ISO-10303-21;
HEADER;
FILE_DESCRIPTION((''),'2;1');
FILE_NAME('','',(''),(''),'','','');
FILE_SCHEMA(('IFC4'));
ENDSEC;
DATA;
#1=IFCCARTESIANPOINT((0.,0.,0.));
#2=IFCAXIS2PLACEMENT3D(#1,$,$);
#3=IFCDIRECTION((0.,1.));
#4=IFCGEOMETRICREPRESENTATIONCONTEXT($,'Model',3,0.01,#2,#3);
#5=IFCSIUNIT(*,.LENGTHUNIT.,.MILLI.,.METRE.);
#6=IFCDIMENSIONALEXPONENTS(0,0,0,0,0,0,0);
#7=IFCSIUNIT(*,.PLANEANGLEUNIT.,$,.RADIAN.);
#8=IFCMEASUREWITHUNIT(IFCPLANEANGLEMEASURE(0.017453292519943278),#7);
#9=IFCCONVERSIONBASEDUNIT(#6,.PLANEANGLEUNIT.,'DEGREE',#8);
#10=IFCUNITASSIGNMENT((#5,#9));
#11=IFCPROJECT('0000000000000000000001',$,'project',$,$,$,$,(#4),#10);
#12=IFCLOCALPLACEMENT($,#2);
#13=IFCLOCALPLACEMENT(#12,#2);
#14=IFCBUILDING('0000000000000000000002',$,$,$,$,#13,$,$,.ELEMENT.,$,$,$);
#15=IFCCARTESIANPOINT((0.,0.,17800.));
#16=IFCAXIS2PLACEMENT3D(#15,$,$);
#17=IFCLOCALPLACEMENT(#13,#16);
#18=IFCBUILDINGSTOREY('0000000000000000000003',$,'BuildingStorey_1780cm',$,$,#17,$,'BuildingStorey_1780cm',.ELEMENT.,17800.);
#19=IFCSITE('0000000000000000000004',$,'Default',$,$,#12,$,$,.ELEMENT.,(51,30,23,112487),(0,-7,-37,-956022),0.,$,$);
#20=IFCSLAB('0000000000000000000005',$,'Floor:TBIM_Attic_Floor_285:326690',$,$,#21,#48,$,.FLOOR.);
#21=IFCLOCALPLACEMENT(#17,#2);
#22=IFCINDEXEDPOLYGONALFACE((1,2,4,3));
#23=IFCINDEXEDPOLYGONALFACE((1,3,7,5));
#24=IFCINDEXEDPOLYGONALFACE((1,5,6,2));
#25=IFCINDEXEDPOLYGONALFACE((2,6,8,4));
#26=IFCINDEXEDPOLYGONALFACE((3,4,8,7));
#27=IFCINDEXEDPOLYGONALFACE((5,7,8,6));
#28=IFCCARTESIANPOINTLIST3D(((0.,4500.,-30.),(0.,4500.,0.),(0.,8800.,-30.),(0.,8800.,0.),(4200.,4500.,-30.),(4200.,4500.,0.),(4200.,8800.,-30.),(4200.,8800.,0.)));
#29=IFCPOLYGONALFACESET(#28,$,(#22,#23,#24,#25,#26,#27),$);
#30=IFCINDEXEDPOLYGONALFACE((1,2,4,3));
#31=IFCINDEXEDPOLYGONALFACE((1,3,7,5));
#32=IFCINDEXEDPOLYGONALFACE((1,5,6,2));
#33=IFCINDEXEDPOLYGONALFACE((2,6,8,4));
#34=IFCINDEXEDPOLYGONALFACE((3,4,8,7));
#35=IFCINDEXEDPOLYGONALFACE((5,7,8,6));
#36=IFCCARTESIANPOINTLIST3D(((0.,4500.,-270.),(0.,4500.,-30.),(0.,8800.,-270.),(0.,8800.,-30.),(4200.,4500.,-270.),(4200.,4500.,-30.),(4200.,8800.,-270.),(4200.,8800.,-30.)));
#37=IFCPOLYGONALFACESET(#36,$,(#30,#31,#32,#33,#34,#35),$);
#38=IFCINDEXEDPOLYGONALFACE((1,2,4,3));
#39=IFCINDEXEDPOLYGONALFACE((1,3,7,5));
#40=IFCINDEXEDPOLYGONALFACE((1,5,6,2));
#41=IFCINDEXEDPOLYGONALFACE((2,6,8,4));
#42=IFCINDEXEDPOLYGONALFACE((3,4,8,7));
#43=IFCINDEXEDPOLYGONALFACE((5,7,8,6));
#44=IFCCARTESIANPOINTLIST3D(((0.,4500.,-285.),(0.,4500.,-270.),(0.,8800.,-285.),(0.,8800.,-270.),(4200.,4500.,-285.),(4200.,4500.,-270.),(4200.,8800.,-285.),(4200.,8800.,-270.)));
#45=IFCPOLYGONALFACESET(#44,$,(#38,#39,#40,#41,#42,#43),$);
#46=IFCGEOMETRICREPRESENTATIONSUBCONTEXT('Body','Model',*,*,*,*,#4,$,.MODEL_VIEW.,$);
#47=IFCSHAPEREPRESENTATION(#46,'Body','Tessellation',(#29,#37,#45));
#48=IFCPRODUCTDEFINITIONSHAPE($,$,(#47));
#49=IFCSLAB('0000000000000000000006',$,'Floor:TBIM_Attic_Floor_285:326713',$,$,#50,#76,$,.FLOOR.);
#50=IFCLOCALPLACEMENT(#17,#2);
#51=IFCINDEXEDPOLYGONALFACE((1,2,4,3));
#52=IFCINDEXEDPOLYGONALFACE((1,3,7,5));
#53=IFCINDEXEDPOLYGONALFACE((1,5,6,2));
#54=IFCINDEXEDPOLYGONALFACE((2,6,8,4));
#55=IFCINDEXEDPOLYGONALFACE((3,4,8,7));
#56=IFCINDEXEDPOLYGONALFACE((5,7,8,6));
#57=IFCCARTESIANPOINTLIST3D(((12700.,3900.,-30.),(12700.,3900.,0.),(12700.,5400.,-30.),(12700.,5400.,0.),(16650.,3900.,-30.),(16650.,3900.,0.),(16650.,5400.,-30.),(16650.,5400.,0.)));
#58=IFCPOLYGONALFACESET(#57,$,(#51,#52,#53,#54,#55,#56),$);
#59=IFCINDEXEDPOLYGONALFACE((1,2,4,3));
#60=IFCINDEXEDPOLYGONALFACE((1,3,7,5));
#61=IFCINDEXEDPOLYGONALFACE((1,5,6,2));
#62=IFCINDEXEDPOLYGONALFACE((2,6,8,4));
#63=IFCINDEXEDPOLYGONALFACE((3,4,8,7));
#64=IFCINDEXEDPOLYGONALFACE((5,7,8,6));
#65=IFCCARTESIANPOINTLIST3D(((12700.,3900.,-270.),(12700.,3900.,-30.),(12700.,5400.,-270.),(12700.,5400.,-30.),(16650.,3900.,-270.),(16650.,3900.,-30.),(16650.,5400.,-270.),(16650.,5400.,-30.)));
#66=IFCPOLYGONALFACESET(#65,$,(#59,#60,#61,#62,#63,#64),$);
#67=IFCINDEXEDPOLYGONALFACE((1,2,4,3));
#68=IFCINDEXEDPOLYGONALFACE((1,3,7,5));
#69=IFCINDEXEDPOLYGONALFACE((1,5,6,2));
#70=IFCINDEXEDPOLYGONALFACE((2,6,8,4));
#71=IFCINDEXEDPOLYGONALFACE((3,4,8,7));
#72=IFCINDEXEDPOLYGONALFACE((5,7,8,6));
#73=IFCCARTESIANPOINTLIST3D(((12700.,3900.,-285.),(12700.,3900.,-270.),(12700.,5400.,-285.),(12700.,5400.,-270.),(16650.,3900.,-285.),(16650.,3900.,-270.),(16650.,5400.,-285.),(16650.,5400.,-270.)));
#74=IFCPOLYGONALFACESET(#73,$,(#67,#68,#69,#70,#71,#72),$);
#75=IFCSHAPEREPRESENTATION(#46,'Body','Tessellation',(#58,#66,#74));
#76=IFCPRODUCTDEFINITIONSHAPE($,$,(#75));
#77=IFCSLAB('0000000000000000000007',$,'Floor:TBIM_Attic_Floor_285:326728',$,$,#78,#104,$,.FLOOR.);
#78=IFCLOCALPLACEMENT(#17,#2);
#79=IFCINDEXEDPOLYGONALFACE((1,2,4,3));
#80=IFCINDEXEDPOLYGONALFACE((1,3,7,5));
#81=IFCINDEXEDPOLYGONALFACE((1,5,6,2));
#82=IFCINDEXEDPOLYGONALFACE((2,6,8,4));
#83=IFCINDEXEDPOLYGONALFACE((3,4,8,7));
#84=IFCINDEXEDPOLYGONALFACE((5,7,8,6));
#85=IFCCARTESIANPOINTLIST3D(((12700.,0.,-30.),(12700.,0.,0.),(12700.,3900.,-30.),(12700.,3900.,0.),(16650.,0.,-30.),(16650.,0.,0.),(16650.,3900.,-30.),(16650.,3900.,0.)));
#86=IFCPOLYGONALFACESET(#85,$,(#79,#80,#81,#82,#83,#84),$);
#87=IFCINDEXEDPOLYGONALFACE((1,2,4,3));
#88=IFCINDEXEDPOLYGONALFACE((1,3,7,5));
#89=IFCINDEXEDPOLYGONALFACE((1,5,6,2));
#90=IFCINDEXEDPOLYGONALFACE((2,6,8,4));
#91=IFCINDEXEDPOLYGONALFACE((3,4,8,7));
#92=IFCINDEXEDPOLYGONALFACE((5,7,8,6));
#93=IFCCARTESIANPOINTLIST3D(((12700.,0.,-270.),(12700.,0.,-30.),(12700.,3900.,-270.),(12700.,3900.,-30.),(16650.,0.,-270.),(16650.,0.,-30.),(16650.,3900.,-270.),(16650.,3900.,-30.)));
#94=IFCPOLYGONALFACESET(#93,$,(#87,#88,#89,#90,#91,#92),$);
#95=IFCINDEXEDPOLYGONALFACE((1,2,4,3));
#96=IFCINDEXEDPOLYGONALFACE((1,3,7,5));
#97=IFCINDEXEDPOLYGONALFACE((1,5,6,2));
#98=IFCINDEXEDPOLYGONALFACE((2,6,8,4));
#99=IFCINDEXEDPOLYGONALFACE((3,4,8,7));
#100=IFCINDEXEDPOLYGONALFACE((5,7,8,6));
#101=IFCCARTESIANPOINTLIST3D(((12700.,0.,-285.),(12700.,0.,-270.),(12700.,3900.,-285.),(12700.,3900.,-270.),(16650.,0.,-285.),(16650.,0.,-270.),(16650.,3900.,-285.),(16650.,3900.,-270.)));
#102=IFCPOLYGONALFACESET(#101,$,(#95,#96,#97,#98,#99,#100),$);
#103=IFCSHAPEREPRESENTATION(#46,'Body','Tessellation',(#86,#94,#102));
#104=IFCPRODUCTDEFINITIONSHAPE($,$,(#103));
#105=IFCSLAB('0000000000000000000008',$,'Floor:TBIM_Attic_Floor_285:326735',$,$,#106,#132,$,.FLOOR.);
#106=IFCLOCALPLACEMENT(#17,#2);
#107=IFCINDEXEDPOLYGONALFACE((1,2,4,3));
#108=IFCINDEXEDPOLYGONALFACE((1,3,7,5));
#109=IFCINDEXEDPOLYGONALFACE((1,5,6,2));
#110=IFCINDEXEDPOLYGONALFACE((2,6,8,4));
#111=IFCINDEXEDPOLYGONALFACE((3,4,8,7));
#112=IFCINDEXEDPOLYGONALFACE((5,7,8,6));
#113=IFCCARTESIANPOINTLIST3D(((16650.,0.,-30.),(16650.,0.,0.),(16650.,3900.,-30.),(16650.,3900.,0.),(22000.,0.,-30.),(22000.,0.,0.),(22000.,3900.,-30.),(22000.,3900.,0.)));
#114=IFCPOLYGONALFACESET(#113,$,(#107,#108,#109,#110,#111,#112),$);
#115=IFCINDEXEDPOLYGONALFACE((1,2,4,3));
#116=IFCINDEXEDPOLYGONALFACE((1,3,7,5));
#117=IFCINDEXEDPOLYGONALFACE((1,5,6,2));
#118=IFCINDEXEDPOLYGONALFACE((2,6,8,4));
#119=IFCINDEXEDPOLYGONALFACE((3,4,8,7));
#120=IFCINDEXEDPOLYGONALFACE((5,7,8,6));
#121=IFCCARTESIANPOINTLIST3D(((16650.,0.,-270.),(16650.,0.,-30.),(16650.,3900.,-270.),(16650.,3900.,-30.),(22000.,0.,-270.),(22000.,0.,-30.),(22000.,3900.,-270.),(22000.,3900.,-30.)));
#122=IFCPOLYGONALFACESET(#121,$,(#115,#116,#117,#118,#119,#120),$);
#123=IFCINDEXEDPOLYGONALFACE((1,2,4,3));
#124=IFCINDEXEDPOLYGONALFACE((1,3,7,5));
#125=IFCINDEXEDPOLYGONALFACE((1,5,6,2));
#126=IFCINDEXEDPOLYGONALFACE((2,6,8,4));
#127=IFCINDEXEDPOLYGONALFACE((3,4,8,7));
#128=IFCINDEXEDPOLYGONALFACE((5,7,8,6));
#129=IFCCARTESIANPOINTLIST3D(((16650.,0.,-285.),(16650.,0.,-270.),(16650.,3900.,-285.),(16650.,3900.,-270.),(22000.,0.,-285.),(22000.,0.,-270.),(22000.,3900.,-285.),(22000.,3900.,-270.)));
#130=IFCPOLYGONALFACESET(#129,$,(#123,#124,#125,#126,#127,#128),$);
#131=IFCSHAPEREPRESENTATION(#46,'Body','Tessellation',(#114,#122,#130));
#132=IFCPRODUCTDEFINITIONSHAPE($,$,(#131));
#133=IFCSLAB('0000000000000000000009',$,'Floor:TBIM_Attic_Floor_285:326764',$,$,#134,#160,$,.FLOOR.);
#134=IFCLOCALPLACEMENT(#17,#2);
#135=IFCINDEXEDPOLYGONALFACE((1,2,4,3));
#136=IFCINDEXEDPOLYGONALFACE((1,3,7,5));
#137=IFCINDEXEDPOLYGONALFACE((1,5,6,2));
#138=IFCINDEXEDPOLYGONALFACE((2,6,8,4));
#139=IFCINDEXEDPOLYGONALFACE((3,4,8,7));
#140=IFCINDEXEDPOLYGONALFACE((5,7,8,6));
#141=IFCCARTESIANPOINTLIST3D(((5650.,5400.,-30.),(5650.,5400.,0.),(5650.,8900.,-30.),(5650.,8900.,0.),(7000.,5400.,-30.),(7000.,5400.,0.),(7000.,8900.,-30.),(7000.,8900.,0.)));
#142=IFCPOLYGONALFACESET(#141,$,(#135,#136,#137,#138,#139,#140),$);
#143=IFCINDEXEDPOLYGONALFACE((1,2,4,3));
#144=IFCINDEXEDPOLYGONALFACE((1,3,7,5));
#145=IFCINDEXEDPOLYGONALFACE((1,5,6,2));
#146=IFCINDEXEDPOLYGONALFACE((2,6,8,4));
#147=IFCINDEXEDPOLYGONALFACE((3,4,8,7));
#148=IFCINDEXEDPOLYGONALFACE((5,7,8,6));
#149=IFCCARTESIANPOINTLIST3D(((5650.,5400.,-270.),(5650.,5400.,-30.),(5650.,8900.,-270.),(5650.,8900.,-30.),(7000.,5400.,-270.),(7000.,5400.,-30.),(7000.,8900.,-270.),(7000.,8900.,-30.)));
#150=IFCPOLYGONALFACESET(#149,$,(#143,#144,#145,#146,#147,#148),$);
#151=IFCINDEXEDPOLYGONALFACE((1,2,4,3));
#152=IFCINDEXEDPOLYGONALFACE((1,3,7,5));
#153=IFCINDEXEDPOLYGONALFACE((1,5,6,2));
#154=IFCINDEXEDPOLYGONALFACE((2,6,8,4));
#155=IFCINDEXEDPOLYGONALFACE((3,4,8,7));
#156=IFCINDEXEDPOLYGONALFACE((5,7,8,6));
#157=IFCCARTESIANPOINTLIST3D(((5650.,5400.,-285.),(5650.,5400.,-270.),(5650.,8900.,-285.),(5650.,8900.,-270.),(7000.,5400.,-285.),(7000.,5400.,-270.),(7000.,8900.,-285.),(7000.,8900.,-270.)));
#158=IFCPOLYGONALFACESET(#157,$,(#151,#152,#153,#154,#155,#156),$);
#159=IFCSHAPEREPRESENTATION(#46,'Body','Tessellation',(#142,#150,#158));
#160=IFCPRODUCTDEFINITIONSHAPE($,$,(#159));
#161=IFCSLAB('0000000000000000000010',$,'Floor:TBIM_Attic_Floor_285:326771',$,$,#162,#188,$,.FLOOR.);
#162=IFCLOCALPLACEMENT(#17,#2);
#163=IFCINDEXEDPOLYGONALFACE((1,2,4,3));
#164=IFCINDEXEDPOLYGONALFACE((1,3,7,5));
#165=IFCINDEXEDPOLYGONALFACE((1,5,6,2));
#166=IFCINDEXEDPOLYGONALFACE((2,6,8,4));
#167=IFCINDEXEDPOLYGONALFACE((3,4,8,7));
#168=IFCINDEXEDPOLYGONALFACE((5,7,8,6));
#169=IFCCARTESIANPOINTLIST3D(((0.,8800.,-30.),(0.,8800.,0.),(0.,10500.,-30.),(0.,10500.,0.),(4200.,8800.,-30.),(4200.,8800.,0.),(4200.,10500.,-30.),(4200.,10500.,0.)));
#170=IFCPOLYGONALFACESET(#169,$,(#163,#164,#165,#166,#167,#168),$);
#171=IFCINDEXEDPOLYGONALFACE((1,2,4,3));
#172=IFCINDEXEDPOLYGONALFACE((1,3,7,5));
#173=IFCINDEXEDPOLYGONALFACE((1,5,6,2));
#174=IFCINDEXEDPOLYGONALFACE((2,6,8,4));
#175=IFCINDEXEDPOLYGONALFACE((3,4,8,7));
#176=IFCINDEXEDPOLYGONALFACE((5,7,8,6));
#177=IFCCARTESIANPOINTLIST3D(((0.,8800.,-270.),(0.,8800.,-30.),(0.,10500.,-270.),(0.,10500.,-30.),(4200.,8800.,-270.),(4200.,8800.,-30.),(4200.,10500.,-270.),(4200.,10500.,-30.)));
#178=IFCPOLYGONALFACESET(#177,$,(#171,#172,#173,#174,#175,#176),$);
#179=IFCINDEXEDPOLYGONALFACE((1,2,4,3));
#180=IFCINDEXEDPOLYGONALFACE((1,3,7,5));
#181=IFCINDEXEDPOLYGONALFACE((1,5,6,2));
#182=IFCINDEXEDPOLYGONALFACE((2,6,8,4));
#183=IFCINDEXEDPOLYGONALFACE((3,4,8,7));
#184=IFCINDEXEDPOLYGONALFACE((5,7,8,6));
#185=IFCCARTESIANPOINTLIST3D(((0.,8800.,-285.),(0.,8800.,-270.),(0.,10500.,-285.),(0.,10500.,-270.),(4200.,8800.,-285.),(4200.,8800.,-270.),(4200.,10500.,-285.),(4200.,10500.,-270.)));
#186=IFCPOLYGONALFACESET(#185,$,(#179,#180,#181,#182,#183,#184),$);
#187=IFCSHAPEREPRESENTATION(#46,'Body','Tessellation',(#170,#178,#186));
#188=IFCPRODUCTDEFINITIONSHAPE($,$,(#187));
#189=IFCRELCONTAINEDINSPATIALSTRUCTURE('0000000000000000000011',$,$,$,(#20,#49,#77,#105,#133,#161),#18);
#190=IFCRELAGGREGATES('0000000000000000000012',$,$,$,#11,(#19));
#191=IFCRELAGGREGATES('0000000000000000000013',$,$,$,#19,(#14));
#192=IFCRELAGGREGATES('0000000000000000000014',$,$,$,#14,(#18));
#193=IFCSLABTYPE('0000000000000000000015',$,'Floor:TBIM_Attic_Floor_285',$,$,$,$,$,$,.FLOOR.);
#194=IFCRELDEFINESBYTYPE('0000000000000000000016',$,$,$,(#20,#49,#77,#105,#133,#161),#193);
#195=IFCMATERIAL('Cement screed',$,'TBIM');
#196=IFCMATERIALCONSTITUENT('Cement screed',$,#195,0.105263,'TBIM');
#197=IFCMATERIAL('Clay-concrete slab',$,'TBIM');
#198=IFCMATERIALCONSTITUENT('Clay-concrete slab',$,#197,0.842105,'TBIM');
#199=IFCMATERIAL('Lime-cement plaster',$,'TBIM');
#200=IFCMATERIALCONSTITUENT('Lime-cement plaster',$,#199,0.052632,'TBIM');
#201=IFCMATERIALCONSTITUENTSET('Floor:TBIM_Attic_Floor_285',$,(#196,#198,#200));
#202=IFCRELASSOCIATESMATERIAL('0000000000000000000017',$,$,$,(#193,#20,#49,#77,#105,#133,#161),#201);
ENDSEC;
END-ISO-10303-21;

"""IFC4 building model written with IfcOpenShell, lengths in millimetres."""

from ifc_helpers import new_model, entity, si_unit, converted_unit, direction, frame, origin, place, context, subcontext, project, spatial, indexed_curve, outline, extrude, material, constituent, constituent_set, type_object, element, save


model = new_model("IFC4")

# Units and contexts
model_context = context("Model", 3, precision=0.01, world=origin(), true_north=direction((0.0, 1.0)))
body_context = subcontext(model_context, "Body", "Model", "MODEL_VIEW")
ifc_project = project(units=[si_unit("LENGTHUNIT", "METRE", prefix="MILLI"), converted_unit("PLANEANGLEUNIT", "DEGREE", entity("IfcPlaneAngleMeasure", 0.017453292519943278), si_unit("PLANEANGLEUNIT", "RADIAN"), dimensions=[0, 0, 0, 0, 0, 0, 0])], contexts=[model_context])

# Site, building, storey
site_placement = place(None, origin())
site = spatial("IfcSite", under=ifc_project, at=site_placement, Name="Default", CompositionType="ELEMENT", RefLatitude=(51, 30, 23, 112487), RefLongitude=(0, -7, -37, -956022), RefElevation=0.0)
building_placement = place(site_placement, origin())
building = spatial("IfcBuilding", under=site, at=building_placement, CompositionType="ELEMENT")
storey_placement = place(building_placement, frame((0.0, 0.0, 17800.0)))
storey = spatial("IfcBuildingStorey", under=building, at=storey_placement, Name="BuildingStorey_1780cm", LongName="BuildingStorey_1780cm", CompositionType="ELEMENT", Elevation=17800.0)

# Slabs
ifc_material_1 = material(Name="Cement screed", Category="TBIM")
ifc_material_2 = material(Name="Clay-concrete slab", Category="TBIM")
ifc_material_3 = material(Name="Lime-cement plaster", Category="TBIM")
ifc_constituent_1 = constituent(ifc_material_1, Name="Cement screed", Category="TBIM", fraction=0.105263)
ifc_constituent_2 = constituent(ifc_material_2, Name="Clay-concrete slab", Category="TBIM", fraction=0.842105)
ifc_constituent_3 = constituent(ifc_material_3, Name="Lime-cement plaster", Category="TBIM", fraction=0.052632)
ifc_constituent_set_1 = constituent_set(constituents=[ifc_constituent_1, ifc_constituent_2, ifc_constituent_3], Name="Floor:TBIM_Attic_Floor_285")
slab_type_1 = type_object("IfcSlabType", Name="Floor:TBIM_Attic_Floor_285", PredefinedType="FLOOR", material=ifc_constituent_set_1)
slab_1_placement = place(storey_placement, origin())
element("IfcSlab", 1, at=slab_1_placement, inside=storey, type_object=slab_type_1, material=ifc_constituent_set_1, Name="Floor:TBIM_Attic_Floor_285:326690", PredefinedType="FLOOR", context=body_context, shape_type="SweptSolid", body=[
    extrude(outline(indexed_curve([(-2100.0, -2150.0), (2100.0, -2150.0), (2100.0, 2150.0), (-2100.0, 2150.0), (-2100.0, -2150.0)], self_intersect=False)), frame((2100.0, 6650.0, -30.0), z_axis=(0.0, 0.0, 1.0), x_axis=(-1.0, 0.0, 0.0)), (0.0, 0.0, 1.0), 30.0),
    extrude(outline(indexed_curve([(-2100.0, -2150.0), (2100.0, -2150.0), (2100.0, 2150.0), (-2100.0, 2150.0), (-2100.0, -2150.0)], self_intersect=False)), frame((2100.0, 6650.0, -270.0), z_axis=(0.0, 0.0, 1.0), x_axis=(-1.0, 0.0, 0.0)), (0.0, 0.0, 1.0), 240.0),
    extrude(outline(indexed_curve([(-2100.0, -2150.0), (2100.0, -2150.0), (2100.0, 2150.0), (-2100.0, 2150.0), (-2100.0, -2150.0)], self_intersect=False)), frame((2100.0, 6650.0, -285.0), z_axis=(0.0, 0.0, 1.0), x_axis=(-1.0, 0.0, 0.0)), (0.0, 0.0, 1.0), 15.0),
])
slab_2_placement = place(storey_placement, origin())
element("IfcSlab", 2, at=slab_2_placement, inside=storey, type_object=slab_type_1, material=ifc_constituent_set_1, Name="Floor:TBIM_Attic_Floor_285:326713", PredefinedType="FLOOR", context=body_context, shape_type="SweptSolid", body=[
    extrude(outline(indexed_curve([(-750.0, -1975.0), (750.0, -1975.0), (750.0, 1975.0), (-750.0, 1975.0), (-750.0, -1975.0)], self_intersect=False)), frame((14675.0, 4650.0, -30.0), z_axis=(0.0, 0.0, 1.0), x_axis=(0.0, 1.0, 0.0)), (0.0, 0.0, 1.0), 30.0),
    extrude(outline(indexed_curve([(-750.0, -1975.0), (750.0, -1975.0), (750.0, 1975.0), (-750.0, 1975.0), (-750.0, -1975.0)], self_intersect=False)), frame((14675.0, 4650.0, -270.0), z_axis=(0.0, 0.0, 1.0), x_axis=(0.0, 1.0, 0.0)), (0.0, 0.0, 1.0), 240.0),
    extrude(outline(indexed_curve([(-750.0, -1975.0), (750.0, -1975.0), (750.0, 1975.0), (-750.0, 1975.0), (-750.0, -1975.0)], self_intersect=False)), frame((14675.0, 4650.0, -285.0), z_axis=(0.0, 0.0, 1.0), x_axis=(0.0, 1.0, 0.0)), (0.0, 0.0, 1.0), 15.0),
])
slab_3_placement = place(storey_placement, origin())
element("IfcSlab", 3, at=slab_3_placement, inside=storey, type_object=slab_type_1, material=ifc_constituent_set_1, Name="Floor:TBIM_Attic_Floor_285:326728", PredefinedType="FLOOR", context=body_context, shape_type="SweptSolid", body=[
    extrude(outline(indexed_curve([(-1975.0, -1950.0), (1975.0, -1950.0), (1975.0, 1950.0), (-1975.0, 1950.0), (-1975.0, -1950.0)], self_intersect=False)), frame((14675.0, 1950.0, -30.0), z_axis=(0.0, 0.0, 1.0), x_axis=(-1.0, 0.0, 0.0)), (0.0, 0.0, 1.0), 30.0),
    extrude(outline(indexed_curve([(-1975.0, -1950.0), (1975.0, -1950.0), (1975.0, 1950.0), (-1975.0, 1950.0), (-1975.0, -1950.0)], self_intersect=False)), frame((14675.0, 1950.0, -270.0), z_axis=(0.0, 0.0, 1.0), x_axis=(-1.0, 0.0, 0.0)), (0.0, 0.0, 1.0), 240.0),
    extrude(outline(indexed_curve([(-1975.0, -1950.0), (1975.0, -1950.0), (1975.0, 1950.0), (-1975.0, 1950.0), (-1975.0, -1950.0)], self_intersect=False)), frame((14675.0, 1950.0, -285.0), z_axis=(0.0, 0.0, 1.0), x_axis=(-1.0, 0.0, 0.0)), (0.0, 0.0, 1.0), 15.0),
])
slab_4_placement = place(storey_placement, origin())
element("IfcSlab", 4, at=slab_4_placement, inside=storey, type_object=slab_type_1, material=ifc_constituent_set_1, Name="Floor:TBIM_Attic_Floor_285:326735", PredefinedType="FLOOR", context=body_context, shape_type="SweptSolid", body=[
    extrude(outline(indexed_curve([(-2675.0, -1950.0), (2675.0, -1950.0), (2675.0, 1950.0), (-2675.0, 1950.0), (-2675.0, -1950.0)], self_intersect=False)), frame((19325.0, 1950.0, -30.0), z_axis=(0.0, 0.0, 1.0), x_axis=(-1.0, 0.0, 0.0)), (0.0, 0.0, 1.0), 30.0),
    extrude(outline(indexed_curve([(-2675.0, -1950.0), (2675.0, -1950.0), (2675.0, 1950.0), (-2675.0, 1950.0), (-2675.0, -1950.0)], self_intersect=False)), frame((19325.0, 1950.0, -270.0), z_axis=(0.0, 0.0, 1.0), x_axis=(-1.0, 0.0, 0.0)), (0.0, 0.0, 1.0), 240.0),
    extrude(outline(indexed_curve([(-2675.0, -1950.0), (2675.0, -1950.0), (2675.0, 1950.0), (-2675.0, 1950.0), (-2675.0, -1950.0)], self_intersect=False)), frame((19325.0, 1950.0, -285.0), z_axis=(0.0, 0.0, 1.0), x_axis=(-1.0, 0.0, 0.0)), (0.0, 0.0, 1.0), 15.0),
])
slab_5_placement = place(storey_placement, origin())
element("IfcSlab", 5, at=slab_5_placement, inside=storey, type_object=slab_type_1, material=ifc_constituent_set_1, Name="Floor:TBIM_Attic_Floor_285:326764", PredefinedType="FLOOR", context=body_context, shape_type="SweptSolid", body=[
    extrude(outline(indexed_curve([(-675.0, -1750.0), (675.0, -1750.0), (675.0, 1750.0), (-675.0, 1750.0), (-675.0, -1750.0)], self_intersect=False)), frame((6325.0, 7150.0, -30.0), z_axis=(0.0, 0.0, 1.0), x_axis=(-1.0, 0.0, 0.0)), (0.0, 0.0, 1.0), 30.0),
    extrude(outline(indexed_curve([(-675.0, -1750.0), (675.0, -1750.0), (675.0, 1750.0), (-675.0, 1750.0), (-675.0, -1750.0)], self_intersect=False)), frame((6325.0, 7150.0, -270.0), z_axis=(0.0, 0.0, 1.0), x_axis=(-1.0, 0.0, 0.0)), (0.0, 0.0, 1.0), 240.0),
    extrude(outline(indexed_curve([(-675.0, -1750.0), (675.0, -1750.0), (675.0, 1750.0), (-675.0, 1750.0), (-675.0, -1750.0)], self_intersect=False)), frame((6325.0, 7150.0, -285.0), z_axis=(0.0, 0.0, 1.0), x_axis=(-1.0, 0.0, 0.0)), (0.0, 0.0, 1.0), 15.0),
])
slab_6_placement = place(storey_placement, origin())
element("IfcSlab", 6, at=slab_6_placement, inside=storey, type_object=slab_type_1, material=ifc_constituent_set_1, Name="Floor:TBIM_Attic_Floor_285:326771", PredefinedType="FLOOR", context=body_context, shape_type="SweptSolid", body=[
    extrude(outline(indexed_curve([(-2100.0, -850.0), (2100.0, -850.0), (2100.0, 850.0), (-2100.0, 850.0), (-2100.0, -850.0)], self_intersect=False)), frame((2100.0, 9650.0, -30.0), z_axis=(0.0, 0.0, 1.0), x_axis=(-1.0, 0.0, 0.0)), (0.0, 0.0, 1.0), 30.0),
    extrude(outline(indexed_curve([(-2100.0, -850.0), (2100.0, -850.0), (2100.0, 850.0), (-2100.0, 850.0), (-2100.0, -850.0)], self_intersect=False)), frame((2100.0, 9650.0, -270.0), z_axis=(0.0, 0.0, 1.0), x_axis=(-1.0, 0.0, 0.0)), (0.0, 0.0, 1.0), 240.0),
    extrude(outline(indexed_curve([(-2100.0, -850.0), (2100.0, -850.0), (2100.0, 850.0), (-2100.0, 850.0), (-2100.0, -850.0)], self_intersect=False)), frame((2100.0, 9650.0, -285.0), z_axis=(0.0, 0.0, 1.0), x_axis=(-1.0, 0.0, 0.0)), (0.0, 0.0, 1.0), 15.0),
])

save(model, "model.ifc")
